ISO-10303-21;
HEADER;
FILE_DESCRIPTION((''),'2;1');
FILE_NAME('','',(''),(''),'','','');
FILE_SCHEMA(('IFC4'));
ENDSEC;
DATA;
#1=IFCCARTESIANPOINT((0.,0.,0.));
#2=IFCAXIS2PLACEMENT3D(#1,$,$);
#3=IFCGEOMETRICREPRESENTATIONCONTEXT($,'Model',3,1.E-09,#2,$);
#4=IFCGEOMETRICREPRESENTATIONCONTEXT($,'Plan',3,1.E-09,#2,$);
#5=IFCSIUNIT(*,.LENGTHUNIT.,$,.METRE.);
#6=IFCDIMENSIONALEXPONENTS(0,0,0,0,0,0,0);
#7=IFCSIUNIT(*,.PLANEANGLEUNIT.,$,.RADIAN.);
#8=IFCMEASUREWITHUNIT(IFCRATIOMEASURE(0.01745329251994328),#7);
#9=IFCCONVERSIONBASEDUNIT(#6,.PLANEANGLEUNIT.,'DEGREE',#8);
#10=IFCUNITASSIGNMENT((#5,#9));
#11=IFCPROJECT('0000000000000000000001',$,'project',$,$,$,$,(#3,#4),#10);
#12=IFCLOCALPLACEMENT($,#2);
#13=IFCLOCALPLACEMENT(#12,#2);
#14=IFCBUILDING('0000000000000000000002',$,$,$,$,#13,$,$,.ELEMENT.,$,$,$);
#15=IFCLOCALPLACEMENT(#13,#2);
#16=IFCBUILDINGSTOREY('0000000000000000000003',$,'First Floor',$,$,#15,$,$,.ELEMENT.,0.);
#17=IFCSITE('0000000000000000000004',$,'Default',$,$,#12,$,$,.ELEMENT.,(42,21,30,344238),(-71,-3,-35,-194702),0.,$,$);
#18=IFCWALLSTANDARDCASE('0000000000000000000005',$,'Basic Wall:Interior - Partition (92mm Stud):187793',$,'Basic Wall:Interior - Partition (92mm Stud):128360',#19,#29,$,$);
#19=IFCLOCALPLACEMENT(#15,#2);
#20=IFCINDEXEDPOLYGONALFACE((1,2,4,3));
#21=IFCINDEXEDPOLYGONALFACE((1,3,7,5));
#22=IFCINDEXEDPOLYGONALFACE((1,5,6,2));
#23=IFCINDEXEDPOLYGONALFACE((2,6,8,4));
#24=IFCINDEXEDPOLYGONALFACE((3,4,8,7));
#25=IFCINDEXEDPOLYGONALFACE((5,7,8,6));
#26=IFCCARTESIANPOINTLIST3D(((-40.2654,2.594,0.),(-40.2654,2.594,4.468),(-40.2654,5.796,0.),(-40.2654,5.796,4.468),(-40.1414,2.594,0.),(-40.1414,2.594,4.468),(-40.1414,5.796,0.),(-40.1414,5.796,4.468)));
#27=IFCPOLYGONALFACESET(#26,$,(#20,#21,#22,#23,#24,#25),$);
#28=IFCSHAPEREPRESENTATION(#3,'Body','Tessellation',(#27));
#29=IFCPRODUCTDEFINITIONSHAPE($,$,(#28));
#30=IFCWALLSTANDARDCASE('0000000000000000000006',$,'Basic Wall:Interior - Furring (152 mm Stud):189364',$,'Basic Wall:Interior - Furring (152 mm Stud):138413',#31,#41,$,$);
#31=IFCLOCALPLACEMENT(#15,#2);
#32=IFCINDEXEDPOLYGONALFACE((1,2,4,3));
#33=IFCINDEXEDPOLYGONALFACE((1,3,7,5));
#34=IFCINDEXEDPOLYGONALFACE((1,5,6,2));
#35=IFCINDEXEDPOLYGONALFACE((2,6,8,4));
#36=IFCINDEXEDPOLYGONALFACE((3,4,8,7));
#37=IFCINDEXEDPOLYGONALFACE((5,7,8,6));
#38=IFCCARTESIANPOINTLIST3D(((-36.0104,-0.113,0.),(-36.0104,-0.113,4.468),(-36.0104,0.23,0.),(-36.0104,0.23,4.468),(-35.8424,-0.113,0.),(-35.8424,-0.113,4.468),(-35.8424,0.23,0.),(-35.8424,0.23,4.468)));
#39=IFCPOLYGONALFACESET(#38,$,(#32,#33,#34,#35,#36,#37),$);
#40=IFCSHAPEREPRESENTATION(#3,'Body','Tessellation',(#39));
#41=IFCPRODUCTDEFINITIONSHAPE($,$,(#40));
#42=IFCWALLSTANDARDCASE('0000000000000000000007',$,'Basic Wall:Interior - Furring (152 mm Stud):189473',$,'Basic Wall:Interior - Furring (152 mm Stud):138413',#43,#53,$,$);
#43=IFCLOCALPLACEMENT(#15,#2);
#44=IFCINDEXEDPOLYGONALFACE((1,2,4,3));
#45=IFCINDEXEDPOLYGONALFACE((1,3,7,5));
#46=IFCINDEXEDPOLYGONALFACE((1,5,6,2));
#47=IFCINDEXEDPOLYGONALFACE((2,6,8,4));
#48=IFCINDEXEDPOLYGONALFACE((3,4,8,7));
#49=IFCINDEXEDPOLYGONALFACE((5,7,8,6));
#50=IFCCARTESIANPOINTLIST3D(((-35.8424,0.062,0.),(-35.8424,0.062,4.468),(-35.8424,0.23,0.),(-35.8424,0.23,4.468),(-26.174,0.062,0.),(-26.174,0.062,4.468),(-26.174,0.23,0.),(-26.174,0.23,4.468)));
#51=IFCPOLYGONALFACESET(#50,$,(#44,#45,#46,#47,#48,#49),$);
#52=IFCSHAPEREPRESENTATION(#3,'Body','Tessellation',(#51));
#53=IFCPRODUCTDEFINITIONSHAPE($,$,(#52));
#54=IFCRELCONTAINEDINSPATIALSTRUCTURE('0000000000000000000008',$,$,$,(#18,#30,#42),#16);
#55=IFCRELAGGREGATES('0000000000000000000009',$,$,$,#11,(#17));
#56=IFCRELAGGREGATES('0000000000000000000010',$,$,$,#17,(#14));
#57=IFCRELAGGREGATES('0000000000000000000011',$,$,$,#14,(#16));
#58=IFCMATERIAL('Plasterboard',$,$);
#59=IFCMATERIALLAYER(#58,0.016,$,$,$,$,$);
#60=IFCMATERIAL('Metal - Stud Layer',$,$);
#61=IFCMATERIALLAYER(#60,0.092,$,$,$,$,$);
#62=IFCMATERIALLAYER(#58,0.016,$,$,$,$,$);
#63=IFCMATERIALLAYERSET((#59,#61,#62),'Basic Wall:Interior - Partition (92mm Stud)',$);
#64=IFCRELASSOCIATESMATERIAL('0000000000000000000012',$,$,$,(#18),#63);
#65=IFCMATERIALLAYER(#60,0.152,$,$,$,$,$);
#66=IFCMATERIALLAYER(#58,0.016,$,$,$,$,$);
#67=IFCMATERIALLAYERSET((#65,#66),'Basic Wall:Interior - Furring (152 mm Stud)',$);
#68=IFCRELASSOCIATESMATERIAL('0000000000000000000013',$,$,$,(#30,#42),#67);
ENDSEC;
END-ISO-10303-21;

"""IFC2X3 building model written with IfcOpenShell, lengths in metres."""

from ifc_helpers import new_model, entity, si_unit, converted_unit, frame, frame_2d, origin, place, context, project, spatial, rectangle, extrude, material, layer, layer_set, layer_usage, element, save


model = new_model("IFC2X3")

# Units and contexts
model_context = context("Model", 3, precision=1e-09, world=origin())
plan_context = context("Plan", 3, precision=1e-09, world=origin())
ifc_project = project(units=[si_unit("LENGTHUNIT", "METRE"), converted_unit("PLANEANGLEUNIT", "DEGREE", entity("IfcRatioMeasure", 0.01745329251994328), si_unit("PLANEANGLEUNIT", "RADIAN"), dimensions=[0, 0, 0, 0, 0, 0, 0])], contexts=[model_context, plan_context])

# Site, building, storey
site_placement = place(None, origin())
site = spatial("IfcSite", under=ifc_project, at=site_placement, Name="Default", CompositionType="ELEMENT", RefLatitude=(42, 21, 30, 344238), RefLongitude=(-71, -3, -35, -194702), RefElevation=0.0)
building_placement = place(site_placement, origin())
building = spatial("IfcBuilding", under=site, at=building_placement, CompositionType="ELEMENT")
storey_placement = place(building_placement, origin())
storey = spatial("IfcBuildingStorey", under=building, at=storey_placement, Name="First Floor", CompositionType="ELEMENT", Elevation=0.0)

# Walls
ifc_material_1 = material(Name="Plasterboard")
ifc_layer_1 = layer(ifc_material_1, 0.016)
ifc_material_2 = material(Name="Metal - Stud Layer")
ifc_layer_2 = layer(ifc_material_2, 0.092)
ifc_layer_3 = layer(ifc_material_1, 0.016)
ifc_layer_set_1 = layer_set([ifc_layer_1, ifc_layer_2, ifc_layer_3], Name="Basic Wall:Interior - Partition (92mm Stud)")
ifc_layer_4 = layer(ifc_material_2, 0.152)
ifc_layer_5 = layer(ifc_material_1, 0.016)
ifc_layer_set_2 = layer_set([ifc_layer_4, ifc_layer_5], Name="Basic Wall:Interior - Furring (152 mm Stud)")
ifc_layer_usage_1 = layer_usage(ifc_layer_set_1, "AXIS2", "NEGATIVE", 0.062)
wall_1_placement = place(storey_placement, frame((-40.2034, 2.594, 0.0), z_axis=(0.0, 0.0, 1.0), x_axis=(0.0, 1.0, 0.0)))
element("IfcWallStandardCase", 1, at=wall_1_placement, inside=storey, material=ifc_layer_usage_1, Name="Basic Wall:Interior - Partition (92mm Stud):187793", ObjectType="Basic Wall:Interior - Partition (92mm Stud):128360", context=model_context, shape_type="SweptSolid", body=[
    extrude(rectangle(XDim=3.202, YDim=0.124, at=frame_2d((1.601, 0.0), x_axis=(-1.0, 0.0))), origin(), (0.0, 0.0, 1.0), 4.468),
])
ifc_layer_usage_2 = layer_usage(ifc_layer_set_2, "AXIS2", "POSITIVE", -0.084)
wall_2_placement = place(storey_placement, frame((-35.9264, -0.113, 0.0), z_axis=(0.0, 0.0, 1.0), x_axis=(0.0, 1.0, 0.0)))
element("IfcWallStandardCase", 2, at=wall_2_placement, inside=storey, material=ifc_layer_usage_2, Name="Basic Wall:Interior - Furring (152 mm Stud):189364", ObjectType="Basic Wall:Interior - Furring (152 mm Stud):138413", context=model_context, shape_type="SweptSolid", body=[
    extrude(rectangle(XDim=0.343, YDim=0.168, at=frame_2d((0.1715, 0.0), x_axis=(-1.0, 0.0))), origin(), (0.0, 0.0, 1.0), 4.468),
])
ifc_layer_usage_3 = layer_usage(ifc_layer_set_2, "AXIS2", "POSITIVE", -0.084)
wall_3_placement = place(storey_placement, frame((-35.8424, 0.146, 0.0)))
element("IfcWallStandardCase", 3, at=wall_3_placement, inside=storey, material=ifc_layer_usage_3, Name="Basic Wall:Interior - Furring (152 mm Stud):189473", ObjectType="Basic Wall:Interior - Furring (152 mm Stud):138413", context=model_context, shape_type="SweptSolid", body=[
    extrude(rectangle(XDim=9.6684, YDim=0.168, at=frame_2d((4.8342, 0.0), x_axis=(-1.0, 0.0))), origin(), (0.0, 0.0, 1.0), 4.468),
])

save(model, "model.ifc")
